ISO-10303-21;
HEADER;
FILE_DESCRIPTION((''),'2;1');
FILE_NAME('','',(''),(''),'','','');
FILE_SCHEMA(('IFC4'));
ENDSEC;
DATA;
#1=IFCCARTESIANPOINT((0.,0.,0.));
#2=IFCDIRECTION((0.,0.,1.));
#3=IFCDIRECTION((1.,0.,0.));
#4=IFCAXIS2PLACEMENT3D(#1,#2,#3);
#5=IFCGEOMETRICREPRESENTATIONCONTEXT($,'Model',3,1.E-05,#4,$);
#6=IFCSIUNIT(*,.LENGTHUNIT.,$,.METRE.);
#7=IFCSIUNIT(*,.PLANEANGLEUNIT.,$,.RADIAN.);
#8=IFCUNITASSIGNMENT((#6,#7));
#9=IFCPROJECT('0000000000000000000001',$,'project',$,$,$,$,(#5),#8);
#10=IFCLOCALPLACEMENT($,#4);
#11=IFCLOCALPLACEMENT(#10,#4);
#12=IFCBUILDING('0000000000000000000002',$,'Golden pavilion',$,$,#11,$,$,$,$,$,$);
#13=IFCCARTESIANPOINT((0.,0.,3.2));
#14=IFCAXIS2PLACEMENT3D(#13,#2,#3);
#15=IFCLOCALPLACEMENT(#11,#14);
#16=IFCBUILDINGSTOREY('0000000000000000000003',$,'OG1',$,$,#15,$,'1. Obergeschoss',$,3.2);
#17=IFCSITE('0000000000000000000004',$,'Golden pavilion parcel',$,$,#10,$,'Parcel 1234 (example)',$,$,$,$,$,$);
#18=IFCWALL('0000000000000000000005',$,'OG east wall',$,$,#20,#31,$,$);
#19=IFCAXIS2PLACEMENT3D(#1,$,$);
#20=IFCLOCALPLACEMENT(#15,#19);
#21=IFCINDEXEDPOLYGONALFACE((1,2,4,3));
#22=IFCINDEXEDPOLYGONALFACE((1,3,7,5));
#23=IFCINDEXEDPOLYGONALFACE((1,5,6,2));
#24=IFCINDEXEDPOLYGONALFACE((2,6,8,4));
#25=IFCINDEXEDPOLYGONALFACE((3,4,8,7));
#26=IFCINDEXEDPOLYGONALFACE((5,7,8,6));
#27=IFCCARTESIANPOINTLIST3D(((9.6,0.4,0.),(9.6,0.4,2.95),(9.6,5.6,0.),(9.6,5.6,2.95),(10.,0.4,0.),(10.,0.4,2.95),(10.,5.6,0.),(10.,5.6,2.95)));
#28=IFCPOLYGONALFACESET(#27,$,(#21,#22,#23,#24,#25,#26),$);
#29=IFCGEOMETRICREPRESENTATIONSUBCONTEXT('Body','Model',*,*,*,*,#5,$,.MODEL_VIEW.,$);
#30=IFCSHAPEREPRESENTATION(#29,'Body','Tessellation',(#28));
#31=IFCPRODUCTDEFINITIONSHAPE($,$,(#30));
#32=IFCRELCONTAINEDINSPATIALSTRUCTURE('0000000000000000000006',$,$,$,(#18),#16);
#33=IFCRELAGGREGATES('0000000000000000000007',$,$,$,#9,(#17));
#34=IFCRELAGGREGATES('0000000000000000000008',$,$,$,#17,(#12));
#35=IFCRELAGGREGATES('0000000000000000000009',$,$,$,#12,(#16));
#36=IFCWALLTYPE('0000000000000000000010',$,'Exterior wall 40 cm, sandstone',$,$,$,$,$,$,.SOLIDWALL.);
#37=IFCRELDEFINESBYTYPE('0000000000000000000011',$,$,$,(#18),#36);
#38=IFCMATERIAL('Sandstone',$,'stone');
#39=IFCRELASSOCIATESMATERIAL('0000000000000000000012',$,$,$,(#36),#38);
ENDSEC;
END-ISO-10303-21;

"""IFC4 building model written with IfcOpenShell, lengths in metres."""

from ifc_helpers import new_model, si_unit, frame, origin_with_axes, place, context, subcontext, project, spatial, indexed_curve, outline, extrude, material, type_object, element, save


model = new_model("IFC4")

# Units and contexts
model_context = context("Model", 3, precision=1e-05, world=origin_with_axes())
body_context = subcontext(model_context, "Body", "Model", "MODEL_VIEW")
ifc_project = project(units=[si_unit("LENGTHUNIT", "METRE"), si_unit("PLANEANGLEUNIT", "RADIAN")], contexts=[model_context])

# Site, building, storey
site_placement = place(None, origin_with_axes())
site = spatial("IfcSite", under=ifc_project, at=site_placement, Name="Golden pavilion parcel", LongName="Parcel 1234 (example)")
building_placement = place(site_placement, origin_with_axes())
building = spatial("IfcBuilding", under=site, at=building_placement, Name="Golden pavilion")
storey_placement = place(building_placement, frame((0.0, 0.0, 3.2), z_axis=(0.0, 0.0, 1.0), x_axis=(1.0, 0.0, 0.0)))
storey = spatial("IfcBuildingStorey", under=building, at=storey_placement, Name="OG1", LongName="1. Obergeschoss", Elevation=3.2)

# Shared definitions
ifc_material_1 = material(Name="Sandstone", Category="stone")
wall_type = type_object("IfcWallType", Name="Exterior wall 40 cm, sandstone", PredefinedType="SOLIDWALL", material=ifc_material_1)

# Wall
for number, where, z_axis, x_axis, name in (
    (1, (10.0, 0.4, 0.0), (0.0, 0.0, 1.0), (0.0, 1.0, 0.0), "OG east wall"),
):
    element("IfcWall", number, at=place(storey_placement, frame(where, z_axis=z_axis, x_axis=x_axis)), inside=storey, type_object=wall_type, Name=name, context=body_context, shape_type="SweptSolid", body=[
        extrude(outline(indexed_curve([(0.0, 0.0), (0.0, 0.4), (5.2, 0.4), (5.2, 0.0), (0.0, 0.0)], self_intersect=False)), origin_with_axes(), (0.0, 0.0, 1.0), 2.95),
    ])

save(model, "model.ifc")
